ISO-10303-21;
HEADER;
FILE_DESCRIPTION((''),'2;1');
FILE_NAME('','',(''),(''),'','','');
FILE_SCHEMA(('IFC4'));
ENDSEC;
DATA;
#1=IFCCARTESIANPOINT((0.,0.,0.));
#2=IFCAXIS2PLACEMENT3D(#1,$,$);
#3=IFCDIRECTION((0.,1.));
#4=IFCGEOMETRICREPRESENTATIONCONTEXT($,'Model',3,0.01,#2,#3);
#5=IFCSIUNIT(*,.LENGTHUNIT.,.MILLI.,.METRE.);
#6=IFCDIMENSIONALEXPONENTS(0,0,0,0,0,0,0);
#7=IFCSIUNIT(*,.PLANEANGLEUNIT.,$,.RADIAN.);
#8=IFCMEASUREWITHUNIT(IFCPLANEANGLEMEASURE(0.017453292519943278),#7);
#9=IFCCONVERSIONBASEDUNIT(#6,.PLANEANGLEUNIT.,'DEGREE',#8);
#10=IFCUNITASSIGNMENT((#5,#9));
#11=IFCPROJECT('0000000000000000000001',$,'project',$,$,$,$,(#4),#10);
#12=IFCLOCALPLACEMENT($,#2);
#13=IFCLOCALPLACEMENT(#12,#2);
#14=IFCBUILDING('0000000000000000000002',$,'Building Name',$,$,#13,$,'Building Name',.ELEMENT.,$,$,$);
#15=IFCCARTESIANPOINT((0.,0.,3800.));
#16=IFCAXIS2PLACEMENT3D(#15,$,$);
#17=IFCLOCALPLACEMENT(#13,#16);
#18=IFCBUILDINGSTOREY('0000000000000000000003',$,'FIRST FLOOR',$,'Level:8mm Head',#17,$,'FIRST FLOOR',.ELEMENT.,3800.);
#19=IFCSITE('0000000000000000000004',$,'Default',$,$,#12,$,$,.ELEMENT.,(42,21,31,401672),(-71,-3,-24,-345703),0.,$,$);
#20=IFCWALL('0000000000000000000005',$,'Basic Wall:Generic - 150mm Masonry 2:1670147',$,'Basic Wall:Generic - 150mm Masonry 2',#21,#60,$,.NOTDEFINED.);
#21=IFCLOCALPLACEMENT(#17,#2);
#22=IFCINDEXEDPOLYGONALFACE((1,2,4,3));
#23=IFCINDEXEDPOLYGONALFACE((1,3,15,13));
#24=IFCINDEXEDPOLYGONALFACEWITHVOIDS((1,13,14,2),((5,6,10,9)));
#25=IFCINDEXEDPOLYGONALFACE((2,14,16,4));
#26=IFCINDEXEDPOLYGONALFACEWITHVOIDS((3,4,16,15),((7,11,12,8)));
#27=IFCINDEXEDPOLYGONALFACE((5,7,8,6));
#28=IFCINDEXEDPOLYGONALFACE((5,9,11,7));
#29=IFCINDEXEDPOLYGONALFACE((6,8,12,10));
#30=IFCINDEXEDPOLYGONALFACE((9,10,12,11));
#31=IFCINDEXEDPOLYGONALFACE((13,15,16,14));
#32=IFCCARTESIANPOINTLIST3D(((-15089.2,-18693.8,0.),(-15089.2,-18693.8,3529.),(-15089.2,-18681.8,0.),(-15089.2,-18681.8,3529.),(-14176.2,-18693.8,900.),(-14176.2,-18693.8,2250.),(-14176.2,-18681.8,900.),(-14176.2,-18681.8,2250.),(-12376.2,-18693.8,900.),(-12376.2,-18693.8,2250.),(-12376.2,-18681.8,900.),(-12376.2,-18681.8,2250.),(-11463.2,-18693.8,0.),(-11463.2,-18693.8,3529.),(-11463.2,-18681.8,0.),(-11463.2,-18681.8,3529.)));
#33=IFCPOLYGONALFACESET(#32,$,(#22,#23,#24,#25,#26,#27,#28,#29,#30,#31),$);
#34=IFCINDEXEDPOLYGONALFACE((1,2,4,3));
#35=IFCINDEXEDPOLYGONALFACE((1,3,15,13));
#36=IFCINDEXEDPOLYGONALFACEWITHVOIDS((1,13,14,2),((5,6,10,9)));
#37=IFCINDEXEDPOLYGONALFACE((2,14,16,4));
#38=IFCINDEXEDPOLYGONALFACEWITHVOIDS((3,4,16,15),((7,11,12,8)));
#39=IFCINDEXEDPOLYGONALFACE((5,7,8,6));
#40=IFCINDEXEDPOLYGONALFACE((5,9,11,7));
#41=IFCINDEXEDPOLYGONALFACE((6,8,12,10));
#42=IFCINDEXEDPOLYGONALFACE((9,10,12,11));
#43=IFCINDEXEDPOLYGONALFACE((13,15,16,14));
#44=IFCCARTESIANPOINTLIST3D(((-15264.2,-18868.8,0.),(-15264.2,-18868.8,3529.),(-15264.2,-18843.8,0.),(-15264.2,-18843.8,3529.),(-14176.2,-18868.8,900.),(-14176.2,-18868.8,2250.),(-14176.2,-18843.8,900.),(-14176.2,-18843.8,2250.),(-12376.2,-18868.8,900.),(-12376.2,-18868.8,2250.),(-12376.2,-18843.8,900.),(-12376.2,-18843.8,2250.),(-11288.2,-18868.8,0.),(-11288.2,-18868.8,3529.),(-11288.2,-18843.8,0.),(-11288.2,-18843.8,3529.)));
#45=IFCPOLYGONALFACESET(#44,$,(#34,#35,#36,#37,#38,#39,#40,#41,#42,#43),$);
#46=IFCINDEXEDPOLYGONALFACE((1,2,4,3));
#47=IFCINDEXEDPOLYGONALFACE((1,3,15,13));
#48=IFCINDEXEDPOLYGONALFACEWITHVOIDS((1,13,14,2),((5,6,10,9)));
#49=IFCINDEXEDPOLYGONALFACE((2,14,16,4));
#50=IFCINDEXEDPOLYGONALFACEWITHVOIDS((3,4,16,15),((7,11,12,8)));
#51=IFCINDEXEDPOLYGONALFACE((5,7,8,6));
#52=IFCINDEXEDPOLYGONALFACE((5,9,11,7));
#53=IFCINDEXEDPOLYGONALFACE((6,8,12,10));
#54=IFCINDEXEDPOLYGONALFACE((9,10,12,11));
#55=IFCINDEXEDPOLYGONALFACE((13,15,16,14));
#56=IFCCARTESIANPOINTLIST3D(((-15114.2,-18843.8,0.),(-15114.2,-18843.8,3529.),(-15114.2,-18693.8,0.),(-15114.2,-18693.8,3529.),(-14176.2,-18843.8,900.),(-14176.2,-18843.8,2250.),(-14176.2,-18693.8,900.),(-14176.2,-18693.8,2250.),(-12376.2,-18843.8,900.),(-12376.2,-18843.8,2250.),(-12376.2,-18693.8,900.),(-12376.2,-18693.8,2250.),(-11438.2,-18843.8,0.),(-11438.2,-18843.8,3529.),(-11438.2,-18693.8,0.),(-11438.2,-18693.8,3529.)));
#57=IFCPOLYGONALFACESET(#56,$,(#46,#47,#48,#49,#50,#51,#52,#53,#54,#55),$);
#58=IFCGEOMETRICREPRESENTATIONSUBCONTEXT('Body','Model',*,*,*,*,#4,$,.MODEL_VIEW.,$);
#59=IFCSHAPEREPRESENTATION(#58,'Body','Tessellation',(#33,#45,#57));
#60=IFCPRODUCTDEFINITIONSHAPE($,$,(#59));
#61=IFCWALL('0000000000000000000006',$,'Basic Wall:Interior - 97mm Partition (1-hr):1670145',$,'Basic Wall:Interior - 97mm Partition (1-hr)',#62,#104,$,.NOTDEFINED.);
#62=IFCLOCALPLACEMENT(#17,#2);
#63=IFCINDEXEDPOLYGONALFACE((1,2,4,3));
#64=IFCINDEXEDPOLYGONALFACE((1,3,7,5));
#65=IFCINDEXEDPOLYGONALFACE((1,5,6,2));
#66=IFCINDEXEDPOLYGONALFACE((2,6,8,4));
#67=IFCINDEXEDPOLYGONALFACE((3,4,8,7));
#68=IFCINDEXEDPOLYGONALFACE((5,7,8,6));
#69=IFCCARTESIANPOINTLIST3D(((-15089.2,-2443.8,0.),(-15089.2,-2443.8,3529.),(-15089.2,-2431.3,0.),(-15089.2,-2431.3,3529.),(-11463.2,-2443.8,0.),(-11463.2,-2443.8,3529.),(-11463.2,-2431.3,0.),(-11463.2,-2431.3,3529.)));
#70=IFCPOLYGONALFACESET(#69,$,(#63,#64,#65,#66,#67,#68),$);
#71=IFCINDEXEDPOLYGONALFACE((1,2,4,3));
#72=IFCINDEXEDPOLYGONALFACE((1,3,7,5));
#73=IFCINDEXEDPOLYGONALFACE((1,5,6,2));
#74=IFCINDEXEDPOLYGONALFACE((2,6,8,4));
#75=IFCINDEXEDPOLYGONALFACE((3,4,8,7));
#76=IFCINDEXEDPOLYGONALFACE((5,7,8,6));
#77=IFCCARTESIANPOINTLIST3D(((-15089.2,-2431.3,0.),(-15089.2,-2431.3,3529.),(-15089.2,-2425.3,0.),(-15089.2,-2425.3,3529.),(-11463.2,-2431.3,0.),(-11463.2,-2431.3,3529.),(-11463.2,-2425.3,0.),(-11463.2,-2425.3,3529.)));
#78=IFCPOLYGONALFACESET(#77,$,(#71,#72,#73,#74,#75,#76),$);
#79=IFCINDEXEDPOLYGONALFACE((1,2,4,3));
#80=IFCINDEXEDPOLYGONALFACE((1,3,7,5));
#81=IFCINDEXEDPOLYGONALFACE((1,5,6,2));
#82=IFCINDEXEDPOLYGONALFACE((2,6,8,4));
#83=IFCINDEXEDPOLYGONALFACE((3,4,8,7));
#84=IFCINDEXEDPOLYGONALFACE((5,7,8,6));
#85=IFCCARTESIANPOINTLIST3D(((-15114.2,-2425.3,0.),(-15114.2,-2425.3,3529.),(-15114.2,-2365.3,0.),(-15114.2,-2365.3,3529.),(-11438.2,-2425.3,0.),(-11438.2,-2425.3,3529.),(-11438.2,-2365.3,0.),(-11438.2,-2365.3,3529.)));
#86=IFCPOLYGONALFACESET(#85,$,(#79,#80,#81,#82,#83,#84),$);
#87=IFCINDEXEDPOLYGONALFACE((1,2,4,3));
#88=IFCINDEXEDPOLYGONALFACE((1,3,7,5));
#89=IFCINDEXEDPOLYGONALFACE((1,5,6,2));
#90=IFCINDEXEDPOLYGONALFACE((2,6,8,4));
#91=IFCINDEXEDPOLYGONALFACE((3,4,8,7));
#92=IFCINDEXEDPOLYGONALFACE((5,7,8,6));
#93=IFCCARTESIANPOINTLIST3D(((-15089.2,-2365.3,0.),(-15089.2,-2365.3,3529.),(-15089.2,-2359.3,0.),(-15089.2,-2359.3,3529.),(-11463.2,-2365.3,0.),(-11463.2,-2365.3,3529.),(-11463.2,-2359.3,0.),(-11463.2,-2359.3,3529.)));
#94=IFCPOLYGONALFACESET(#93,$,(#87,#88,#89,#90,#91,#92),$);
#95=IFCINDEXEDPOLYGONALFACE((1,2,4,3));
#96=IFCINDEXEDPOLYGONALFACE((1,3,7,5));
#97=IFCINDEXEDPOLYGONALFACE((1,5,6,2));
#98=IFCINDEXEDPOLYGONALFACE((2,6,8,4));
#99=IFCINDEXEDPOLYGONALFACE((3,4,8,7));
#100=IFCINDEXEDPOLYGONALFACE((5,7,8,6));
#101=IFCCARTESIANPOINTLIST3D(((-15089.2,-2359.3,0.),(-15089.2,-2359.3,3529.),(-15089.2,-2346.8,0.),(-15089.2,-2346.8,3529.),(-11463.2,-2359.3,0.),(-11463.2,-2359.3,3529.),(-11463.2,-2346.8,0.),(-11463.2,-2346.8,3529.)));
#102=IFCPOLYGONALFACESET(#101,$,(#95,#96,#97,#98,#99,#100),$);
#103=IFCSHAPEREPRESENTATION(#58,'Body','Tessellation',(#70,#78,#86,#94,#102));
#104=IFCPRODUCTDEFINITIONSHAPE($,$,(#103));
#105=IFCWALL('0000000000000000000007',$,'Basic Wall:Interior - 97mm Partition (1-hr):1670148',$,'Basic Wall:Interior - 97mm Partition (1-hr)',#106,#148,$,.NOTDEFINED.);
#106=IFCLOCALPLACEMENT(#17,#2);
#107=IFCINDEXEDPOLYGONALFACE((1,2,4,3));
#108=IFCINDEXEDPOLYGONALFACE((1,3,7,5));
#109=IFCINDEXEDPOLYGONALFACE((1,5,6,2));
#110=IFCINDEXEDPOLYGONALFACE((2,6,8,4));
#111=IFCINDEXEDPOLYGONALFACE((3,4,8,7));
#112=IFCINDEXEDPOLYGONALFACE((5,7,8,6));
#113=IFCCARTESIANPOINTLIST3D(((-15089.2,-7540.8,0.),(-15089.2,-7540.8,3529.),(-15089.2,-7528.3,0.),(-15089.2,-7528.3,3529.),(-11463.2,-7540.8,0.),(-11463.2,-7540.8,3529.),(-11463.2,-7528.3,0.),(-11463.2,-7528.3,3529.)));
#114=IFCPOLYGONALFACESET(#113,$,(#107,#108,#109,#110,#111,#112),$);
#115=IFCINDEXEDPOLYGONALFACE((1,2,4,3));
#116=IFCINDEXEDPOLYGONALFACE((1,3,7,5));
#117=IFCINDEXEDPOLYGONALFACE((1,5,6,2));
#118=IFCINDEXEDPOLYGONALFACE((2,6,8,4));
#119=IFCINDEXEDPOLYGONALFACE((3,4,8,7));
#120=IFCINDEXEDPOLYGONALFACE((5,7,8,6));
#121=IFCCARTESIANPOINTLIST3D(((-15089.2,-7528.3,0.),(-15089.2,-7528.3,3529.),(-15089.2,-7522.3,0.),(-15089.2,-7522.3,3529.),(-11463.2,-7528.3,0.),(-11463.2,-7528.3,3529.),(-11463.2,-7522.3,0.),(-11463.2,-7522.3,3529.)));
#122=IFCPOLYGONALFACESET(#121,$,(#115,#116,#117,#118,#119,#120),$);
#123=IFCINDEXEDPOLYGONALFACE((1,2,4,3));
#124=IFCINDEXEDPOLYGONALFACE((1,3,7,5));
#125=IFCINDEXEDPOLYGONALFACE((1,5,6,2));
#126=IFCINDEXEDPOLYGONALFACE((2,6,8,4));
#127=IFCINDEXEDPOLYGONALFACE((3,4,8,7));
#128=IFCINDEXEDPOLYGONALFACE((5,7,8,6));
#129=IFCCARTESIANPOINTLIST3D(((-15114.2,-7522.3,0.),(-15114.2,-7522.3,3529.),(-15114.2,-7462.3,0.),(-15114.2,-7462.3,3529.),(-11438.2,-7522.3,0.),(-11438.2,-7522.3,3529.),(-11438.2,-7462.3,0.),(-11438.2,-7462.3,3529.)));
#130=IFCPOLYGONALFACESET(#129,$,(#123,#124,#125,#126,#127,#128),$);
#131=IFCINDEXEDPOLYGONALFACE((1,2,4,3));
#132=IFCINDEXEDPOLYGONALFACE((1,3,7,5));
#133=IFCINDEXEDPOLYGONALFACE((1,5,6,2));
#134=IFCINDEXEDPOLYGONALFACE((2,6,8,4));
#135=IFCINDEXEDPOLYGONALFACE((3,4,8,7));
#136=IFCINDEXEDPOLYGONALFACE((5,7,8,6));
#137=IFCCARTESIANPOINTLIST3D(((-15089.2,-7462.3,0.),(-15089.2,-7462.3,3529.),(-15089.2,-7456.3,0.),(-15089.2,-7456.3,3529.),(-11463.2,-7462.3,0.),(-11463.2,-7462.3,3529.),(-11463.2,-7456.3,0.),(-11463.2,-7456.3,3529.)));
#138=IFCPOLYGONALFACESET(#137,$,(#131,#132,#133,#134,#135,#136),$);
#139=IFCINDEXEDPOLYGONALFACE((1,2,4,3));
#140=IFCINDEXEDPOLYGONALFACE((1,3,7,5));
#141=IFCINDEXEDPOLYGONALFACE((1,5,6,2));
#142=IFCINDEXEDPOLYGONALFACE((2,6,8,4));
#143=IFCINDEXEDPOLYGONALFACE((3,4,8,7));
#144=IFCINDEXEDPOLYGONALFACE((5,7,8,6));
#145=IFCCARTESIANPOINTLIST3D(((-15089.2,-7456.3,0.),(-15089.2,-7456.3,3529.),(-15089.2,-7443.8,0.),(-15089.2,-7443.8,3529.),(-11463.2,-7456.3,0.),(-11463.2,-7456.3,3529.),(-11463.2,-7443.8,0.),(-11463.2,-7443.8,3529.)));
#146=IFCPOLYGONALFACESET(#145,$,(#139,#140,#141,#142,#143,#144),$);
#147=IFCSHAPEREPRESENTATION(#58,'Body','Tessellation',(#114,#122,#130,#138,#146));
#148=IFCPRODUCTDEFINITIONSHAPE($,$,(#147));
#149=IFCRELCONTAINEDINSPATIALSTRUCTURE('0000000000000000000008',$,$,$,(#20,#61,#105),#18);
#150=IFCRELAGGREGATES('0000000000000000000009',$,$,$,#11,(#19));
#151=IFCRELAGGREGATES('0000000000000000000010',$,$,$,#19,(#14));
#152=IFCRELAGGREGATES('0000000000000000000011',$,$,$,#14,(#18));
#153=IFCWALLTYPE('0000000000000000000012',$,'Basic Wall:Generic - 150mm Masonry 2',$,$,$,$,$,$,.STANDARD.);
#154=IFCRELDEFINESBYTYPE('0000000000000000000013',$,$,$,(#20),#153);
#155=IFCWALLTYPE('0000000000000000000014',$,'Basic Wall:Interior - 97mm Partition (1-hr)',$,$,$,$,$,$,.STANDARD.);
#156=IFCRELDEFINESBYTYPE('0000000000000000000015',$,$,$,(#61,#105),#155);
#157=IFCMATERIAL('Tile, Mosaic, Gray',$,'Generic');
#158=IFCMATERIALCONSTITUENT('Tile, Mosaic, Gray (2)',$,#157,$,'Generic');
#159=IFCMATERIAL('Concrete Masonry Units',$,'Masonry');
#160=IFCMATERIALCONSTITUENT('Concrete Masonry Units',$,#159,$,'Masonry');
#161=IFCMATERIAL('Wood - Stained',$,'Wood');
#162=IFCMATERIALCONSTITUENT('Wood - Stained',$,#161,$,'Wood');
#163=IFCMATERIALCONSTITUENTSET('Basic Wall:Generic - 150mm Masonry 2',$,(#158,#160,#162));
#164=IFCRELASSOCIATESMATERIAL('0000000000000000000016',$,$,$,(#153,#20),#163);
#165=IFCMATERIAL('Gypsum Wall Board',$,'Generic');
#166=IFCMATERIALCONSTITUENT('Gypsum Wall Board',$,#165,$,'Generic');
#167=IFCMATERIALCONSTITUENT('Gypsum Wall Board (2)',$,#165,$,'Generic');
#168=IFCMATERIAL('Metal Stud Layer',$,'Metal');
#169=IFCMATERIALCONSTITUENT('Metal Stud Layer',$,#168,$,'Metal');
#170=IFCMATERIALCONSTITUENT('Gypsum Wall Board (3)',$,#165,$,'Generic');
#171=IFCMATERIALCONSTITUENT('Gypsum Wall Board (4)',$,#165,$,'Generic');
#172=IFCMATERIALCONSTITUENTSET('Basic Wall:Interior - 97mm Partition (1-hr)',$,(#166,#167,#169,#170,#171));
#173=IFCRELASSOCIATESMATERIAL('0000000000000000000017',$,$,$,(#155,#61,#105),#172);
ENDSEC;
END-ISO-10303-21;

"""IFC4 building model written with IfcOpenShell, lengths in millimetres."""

from ifc_helpers import new_model, entity, si_unit, converted_unit, direction, frame, origin, place, context, subcontext, project, spatial, indexed_curve, outline, extrude, material, constituent, constituent_set, type_object, element, save


model = new_model("IFC4")

# Units and contexts
model_context = context("Model", 3, precision=0.01, world=origin(), true_north=direction((0.0, 1.0)))
body_context = subcontext(model_context, "Body", "Model", "MODEL_VIEW")
ifc_project = project(units=[si_unit("LENGTHUNIT", "METRE", prefix="MILLI"), converted_unit("PLANEANGLEUNIT", "DEGREE", entity("IfcPlaneAngleMeasure", 0.017453292519943278), si_unit("PLANEANGLEUNIT", "RADIAN"), dimensions=[0, 0, 0, 0, 0, 0, 0])], contexts=[model_context])

# Site, building, storey
site_placement = place(None, origin())
site = spatial("IfcSite", under=ifc_project, at=site_placement, Name="Default", CompositionType="ELEMENT", RefLatitude=(42, 21, 31, 401672), RefLongitude=(-71, -3, -24, -345703), RefElevation=0.0)
building_placement = place(site_placement, origin())
building = spatial("IfcBuilding", under=site, at=building_placement, Name="Building Name", LongName="Building Name", CompositionType="ELEMENT")
storey_placement = place(building_placement, frame((0.0, 0.0, 3800.0)))
storey = spatial("IfcBuildingStorey", under=building, at=storey_placement, Name="FIRST FLOOR", ObjectType="Level:8mm Head", LongName="FIRST FLOOR", CompositionType="ELEMENT", Elevation=3800.0)

# Shared definitions
ifc_material_1 = material(Name="Tile, Mosaic, Gray", Category="Generic")
ifc_constituent_1 = constituent(ifc_material_1, Name="Tile, Mosaic, Gray (2)", Category="Generic")
ifc_material_2 = material(Name="Concrete Masonry Units", Category="Masonry")
ifc_constituent_2 = constituent(ifc_material_2, Name="Concrete Masonry Units", Category="Masonry")
ifc_material_3 = material(Name="Wood - Stained", Category="Wood")
ifc_constituent_3 = constituent(ifc_material_3, Name="Wood - Stained", Category="Wood")
ifc_constituent_set_1 = constituent_set(constituents=[ifc_constituent_1, ifc_constituent_2, ifc_constituent_3], Name="Basic Wall:Generic - 150mm Masonry 2")
wall_type_1 = type_object("IfcWallType", Name="Basic Wall:Generic - 150mm Masonry 2", PredefinedType="STANDARD", material=ifc_constituent_set_1)

# Wall, opening
wall_1_placement = place(storey_placement, frame((-11463.2, -18775.3, 0.0), z_axis=(0.0, 0.0, 1.0), x_axis=(-1.0, 0.0, 0.0)))
wall_1 = element("IfcWall", 1, at=wall_1_placement, inside=storey, type_object=wall_type_1, material=ifc_constituent_set_1, Name="Basic Wall:Generic - 150mm Masonry 2:1670147", ObjectType="Basic Wall:Generic - 150mm Masonry 2", PredefinedType="NOTDEFINED", context=body_context, shape_type="SweptSolid", body=[
    extrude(outline(indexed_curve([(-1764.5, -1813.0), (1764.5, -1813.0), (1764.5, 1813.0), (-1764.5, 1813.0), (-1764.5, -1813.0)], self_intersect=False), holes=[indexed_curve([(-864.5, -900.0), (-864.5, 900.0), (485.5, 900.0), (485.5, -900.0), (-864.5, -900.0)], self_intersect=False)]), frame((1813.0, -81.5, 1764.5), z_axis=(0.0, -1.0, 0.0), x_axis=(0.0, 0.0, 1.0)), (0.0, 0.0, 1.0), 12.0),
    extrude(outline(indexed_curve([(-1988.0, -1764.5), (1988.0, -1764.5), (1988.0, 1764.5), (-1988.0, 1764.5), (-1988.0, -1764.5)], self_intersect=False), holes=[indexed_curve([(900.0, 485.5), (900.0, -864.5), (-900.0, -864.5), (-900.0, 485.5), (900.0, 485.5)], self_intersect=False)]), frame((1813.0, 93.5, 1764.5), z_axis=(0.0, -1.0, 0.0), x_axis=(1.0, 0.0, 0.0)), (0.0, 0.0, 1.0), 25.0),
    extrude(outline(indexed_curve([(-1764.5, -1838.0), (1764.5, -1838.0), (1764.5, 1838.0), (-1764.5, 1838.0), (-1764.5, -1838.0)], self_intersect=False), holes=[indexed_curve([(-864.5, -900.0), (-864.5, 900.0), (485.5, 900.0), (485.5, -900.0), (-864.5, -900.0)], self_intersect=False)]), frame((1813.0, 68.5, 1764.5), z_axis=(0.0, -1.0, 0.0), x_axis=(0.0, 0.0, 1.0)), (0.0, 0.0, 1.0), 150.0),
])
opening_placement = place(wall_1_placement, frame((913.0, -93.5, 900.0)))
element("IfcOpeningElement", 2, at=opening_placement, cuts=wall_1, PredefinedType="OPENING", context=body_context, shape_type="SweptSolid", body=[
    extrude(outline(indexed_curve([(1350.0, 1800.0), (0.0, 1800.0), (0.0, 0.0), (1350.0, 0.0), (1350.0, 1800.0)], self_intersect=False)), frame((0.0, 0.0, 0.0), z_axis=(0.0, 1.0, 0.0), x_axis=(0.0, 0.0, 1.0)), (0.0, 0.0, 1.0), 187.0),
])

# Walls
ifc_material_4 = material(Name="Gypsum Wall Board", Category="Generic")
ifc_constituent_4 = constituent(ifc_material_4, Name="Gypsum Wall Board", Category="Generic")
ifc_constituent_5 = constituent(ifc_material_4, Name="Gypsum Wall Board (2)", Category="Generic")
ifc_material_5 = material(Name="Metal Stud Layer", Category="Metal")
ifc_constituent_6 = constituent(ifc_material_5, Name="Metal Stud Layer", Category="Metal")
ifc_constituent_7 = constituent(ifc_material_4, Name="Gypsum Wall Board (3)", Category="Generic")
ifc_constituent_8 = constituent(ifc_material_4, Name="Gypsum Wall Board (4)", Category="Generic")
ifc_constituent_set_2 = constituent_set(constituents=[ifc_constituent_4, ifc_constituent_5, ifc_constituent_6, ifc_constituent_7, ifc_constituent_8], Name="Basic Wall:Interior - 97mm Partition (1-hr)")
wall_type_2 = type_object("IfcWallType", Name="Basic Wall:Interior - 97mm Partition (1-hr)", PredefinedType="STANDARD", material=ifc_constituent_set_2)
wall_2_placement = place(storey_placement, frame((-15089.2, -2395.3, 0.0)))
element("IfcWall", 3, at=wall_2_placement, inside=storey, type_object=wall_type_2, material=ifc_constituent_set_2, Name="Basic Wall:Interior - 97mm Partition (1-hr):1670145", ObjectType="Basic Wall:Interior - 97mm Partition (1-hr)", PredefinedType="NOTDEFINED", context=body_context, shape_type="SweptSolid", body=[
    extrude(outline(indexed_curve([(-6.3, -1813.0), (6.2, -1813.0), (6.3, 1813.0), (-6.2, 1813.0), (-6.3, -1813.0)], self_intersect=False)), frame((1813.0, -42.2, 0.0), z_axis=(0.0, 0.0, 1.0), x_axis=(0.0, 1.0, 0.0)), (0.0, 0.0, 1.0), 3529.0),
    extrude(outline(indexed_curve([(-1813.0, -3.0), (1813.0, -3.0), (1813.0, 3.0), (-1813.0, 3.0), (-1813.0, -3.0)], self_intersect=False)), frame((1813.0, -33.0, 0.0)), (0.0, 0.0, 1.0), 3529.0),
    extrude(outline(indexed_curve([(-1838.0, -30.0), (1838.0, -30.0), (1838.0, 30.0), (-1838.0, 30.0), (-1838.0, -30.0)], self_intersect=False)), frame((1813.0, 0.0, 0.0)), (0.0, 0.0, 1.0), 3529.0),
    extrude(outline(indexed_curve([(-1813.0, -3.0), (1813.0, -3.0), (1813.0, 3.0), (-1813.0, 3.0), (-1813.0, -3.0)], self_intersect=False)), frame((1813.0, 33.0, 0.0)), (0.0, 0.0, 1.0), 3529.0),
    extrude(outline(indexed_curve([(-6.3, -1813.0), (6.2, -1813.0), (6.3, 1813.0), (-6.2, 1813.0), (-6.3, -1813.0)], self_intersect=False)), frame((1813.0, 42.3, 0.0), z_axis=(0.0, 0.0, 1.0), x_axis=(0.0, -1.0, 0.0)), (0.0, 0.0, 1.0), 3529.0),
])
wall_3_placement = place(storey_placement, frame((-15089.2, -7492.3, 0.0)))
element("IfcWall", 4, at=wall_3_placement, inside=storey, type_object=wall_type_2, material=ifc_constituent_set_2, Name="Basic Wall:Interior - 97mm Partition (1-hr):1670148", ObjectType="Basic Wall:Interior - 97mm Partition (1-hr)", PredefinedType="NOTDEFINED", context=body_context, shape_type="SweptSolid", body=[
    extrude(outline(indexed_curve([(-6.3, -1813.0), (6.2, -1813.0), (6.3, 1813.0), (-6.2, 1813.0), (-6.3, -1813.0)], self_intersect=False)), frame((1813.0, -42.2, 0.0), z_axis=(0.0, 0.0, 1.0), x_axis=(0.0, 1.0, 0.0)), (0.0, 0.0, 1.0), 3529.0),
    extrude(outline(indexed_curve([(-1813.0, -3.0), (1813.0, -3.0), (1813.0, 3.0), (-1813.0, 3.0), (-1813.0, -3.0)], self_intersect=False)), frame((1813.0, -33.0, 0.0)), (0.0, 0.0, 1.0), 3529.0),
    extrude(outline(indexed_curve([(-1838.0, -30.0), (1838.0, -30.0), (1838.0, 30.0), (-1838.0, 30.0), (-1838.0, -30.0)], self_intersect=False)), frame((1813.0, 0.0, 0.0)), (0.0, 0.0, 1.0), 3529.0),
    extrude(outline(indexed_curve([(-1813.0, -3.0), (1813.0, -3.0), (1813.0, 3.0), (-1813.0, 3.0), (-1813.0, -3.0)], self_intersect=False)), frame((1813.0, 33.0, 0.0)), (0.0, 0.0, 1.0), 3529.0),
    extrude(outline(indexed_curve([(-6.3, -1813.0), (6.2, -1813.0), (6.3, 1813.0), (-6.2, 1813.0), (-6.3, -1813.0)], self_intersect=False)), frame((1813.0, 42.3, 0.0), z_axis=(0.0, 0.0, 1.0), x_axis=(0.0, -1.0, 0.0)), (0.0, 0.0, 1.0), 3529.0),
])

save(model, "model.ifc")
